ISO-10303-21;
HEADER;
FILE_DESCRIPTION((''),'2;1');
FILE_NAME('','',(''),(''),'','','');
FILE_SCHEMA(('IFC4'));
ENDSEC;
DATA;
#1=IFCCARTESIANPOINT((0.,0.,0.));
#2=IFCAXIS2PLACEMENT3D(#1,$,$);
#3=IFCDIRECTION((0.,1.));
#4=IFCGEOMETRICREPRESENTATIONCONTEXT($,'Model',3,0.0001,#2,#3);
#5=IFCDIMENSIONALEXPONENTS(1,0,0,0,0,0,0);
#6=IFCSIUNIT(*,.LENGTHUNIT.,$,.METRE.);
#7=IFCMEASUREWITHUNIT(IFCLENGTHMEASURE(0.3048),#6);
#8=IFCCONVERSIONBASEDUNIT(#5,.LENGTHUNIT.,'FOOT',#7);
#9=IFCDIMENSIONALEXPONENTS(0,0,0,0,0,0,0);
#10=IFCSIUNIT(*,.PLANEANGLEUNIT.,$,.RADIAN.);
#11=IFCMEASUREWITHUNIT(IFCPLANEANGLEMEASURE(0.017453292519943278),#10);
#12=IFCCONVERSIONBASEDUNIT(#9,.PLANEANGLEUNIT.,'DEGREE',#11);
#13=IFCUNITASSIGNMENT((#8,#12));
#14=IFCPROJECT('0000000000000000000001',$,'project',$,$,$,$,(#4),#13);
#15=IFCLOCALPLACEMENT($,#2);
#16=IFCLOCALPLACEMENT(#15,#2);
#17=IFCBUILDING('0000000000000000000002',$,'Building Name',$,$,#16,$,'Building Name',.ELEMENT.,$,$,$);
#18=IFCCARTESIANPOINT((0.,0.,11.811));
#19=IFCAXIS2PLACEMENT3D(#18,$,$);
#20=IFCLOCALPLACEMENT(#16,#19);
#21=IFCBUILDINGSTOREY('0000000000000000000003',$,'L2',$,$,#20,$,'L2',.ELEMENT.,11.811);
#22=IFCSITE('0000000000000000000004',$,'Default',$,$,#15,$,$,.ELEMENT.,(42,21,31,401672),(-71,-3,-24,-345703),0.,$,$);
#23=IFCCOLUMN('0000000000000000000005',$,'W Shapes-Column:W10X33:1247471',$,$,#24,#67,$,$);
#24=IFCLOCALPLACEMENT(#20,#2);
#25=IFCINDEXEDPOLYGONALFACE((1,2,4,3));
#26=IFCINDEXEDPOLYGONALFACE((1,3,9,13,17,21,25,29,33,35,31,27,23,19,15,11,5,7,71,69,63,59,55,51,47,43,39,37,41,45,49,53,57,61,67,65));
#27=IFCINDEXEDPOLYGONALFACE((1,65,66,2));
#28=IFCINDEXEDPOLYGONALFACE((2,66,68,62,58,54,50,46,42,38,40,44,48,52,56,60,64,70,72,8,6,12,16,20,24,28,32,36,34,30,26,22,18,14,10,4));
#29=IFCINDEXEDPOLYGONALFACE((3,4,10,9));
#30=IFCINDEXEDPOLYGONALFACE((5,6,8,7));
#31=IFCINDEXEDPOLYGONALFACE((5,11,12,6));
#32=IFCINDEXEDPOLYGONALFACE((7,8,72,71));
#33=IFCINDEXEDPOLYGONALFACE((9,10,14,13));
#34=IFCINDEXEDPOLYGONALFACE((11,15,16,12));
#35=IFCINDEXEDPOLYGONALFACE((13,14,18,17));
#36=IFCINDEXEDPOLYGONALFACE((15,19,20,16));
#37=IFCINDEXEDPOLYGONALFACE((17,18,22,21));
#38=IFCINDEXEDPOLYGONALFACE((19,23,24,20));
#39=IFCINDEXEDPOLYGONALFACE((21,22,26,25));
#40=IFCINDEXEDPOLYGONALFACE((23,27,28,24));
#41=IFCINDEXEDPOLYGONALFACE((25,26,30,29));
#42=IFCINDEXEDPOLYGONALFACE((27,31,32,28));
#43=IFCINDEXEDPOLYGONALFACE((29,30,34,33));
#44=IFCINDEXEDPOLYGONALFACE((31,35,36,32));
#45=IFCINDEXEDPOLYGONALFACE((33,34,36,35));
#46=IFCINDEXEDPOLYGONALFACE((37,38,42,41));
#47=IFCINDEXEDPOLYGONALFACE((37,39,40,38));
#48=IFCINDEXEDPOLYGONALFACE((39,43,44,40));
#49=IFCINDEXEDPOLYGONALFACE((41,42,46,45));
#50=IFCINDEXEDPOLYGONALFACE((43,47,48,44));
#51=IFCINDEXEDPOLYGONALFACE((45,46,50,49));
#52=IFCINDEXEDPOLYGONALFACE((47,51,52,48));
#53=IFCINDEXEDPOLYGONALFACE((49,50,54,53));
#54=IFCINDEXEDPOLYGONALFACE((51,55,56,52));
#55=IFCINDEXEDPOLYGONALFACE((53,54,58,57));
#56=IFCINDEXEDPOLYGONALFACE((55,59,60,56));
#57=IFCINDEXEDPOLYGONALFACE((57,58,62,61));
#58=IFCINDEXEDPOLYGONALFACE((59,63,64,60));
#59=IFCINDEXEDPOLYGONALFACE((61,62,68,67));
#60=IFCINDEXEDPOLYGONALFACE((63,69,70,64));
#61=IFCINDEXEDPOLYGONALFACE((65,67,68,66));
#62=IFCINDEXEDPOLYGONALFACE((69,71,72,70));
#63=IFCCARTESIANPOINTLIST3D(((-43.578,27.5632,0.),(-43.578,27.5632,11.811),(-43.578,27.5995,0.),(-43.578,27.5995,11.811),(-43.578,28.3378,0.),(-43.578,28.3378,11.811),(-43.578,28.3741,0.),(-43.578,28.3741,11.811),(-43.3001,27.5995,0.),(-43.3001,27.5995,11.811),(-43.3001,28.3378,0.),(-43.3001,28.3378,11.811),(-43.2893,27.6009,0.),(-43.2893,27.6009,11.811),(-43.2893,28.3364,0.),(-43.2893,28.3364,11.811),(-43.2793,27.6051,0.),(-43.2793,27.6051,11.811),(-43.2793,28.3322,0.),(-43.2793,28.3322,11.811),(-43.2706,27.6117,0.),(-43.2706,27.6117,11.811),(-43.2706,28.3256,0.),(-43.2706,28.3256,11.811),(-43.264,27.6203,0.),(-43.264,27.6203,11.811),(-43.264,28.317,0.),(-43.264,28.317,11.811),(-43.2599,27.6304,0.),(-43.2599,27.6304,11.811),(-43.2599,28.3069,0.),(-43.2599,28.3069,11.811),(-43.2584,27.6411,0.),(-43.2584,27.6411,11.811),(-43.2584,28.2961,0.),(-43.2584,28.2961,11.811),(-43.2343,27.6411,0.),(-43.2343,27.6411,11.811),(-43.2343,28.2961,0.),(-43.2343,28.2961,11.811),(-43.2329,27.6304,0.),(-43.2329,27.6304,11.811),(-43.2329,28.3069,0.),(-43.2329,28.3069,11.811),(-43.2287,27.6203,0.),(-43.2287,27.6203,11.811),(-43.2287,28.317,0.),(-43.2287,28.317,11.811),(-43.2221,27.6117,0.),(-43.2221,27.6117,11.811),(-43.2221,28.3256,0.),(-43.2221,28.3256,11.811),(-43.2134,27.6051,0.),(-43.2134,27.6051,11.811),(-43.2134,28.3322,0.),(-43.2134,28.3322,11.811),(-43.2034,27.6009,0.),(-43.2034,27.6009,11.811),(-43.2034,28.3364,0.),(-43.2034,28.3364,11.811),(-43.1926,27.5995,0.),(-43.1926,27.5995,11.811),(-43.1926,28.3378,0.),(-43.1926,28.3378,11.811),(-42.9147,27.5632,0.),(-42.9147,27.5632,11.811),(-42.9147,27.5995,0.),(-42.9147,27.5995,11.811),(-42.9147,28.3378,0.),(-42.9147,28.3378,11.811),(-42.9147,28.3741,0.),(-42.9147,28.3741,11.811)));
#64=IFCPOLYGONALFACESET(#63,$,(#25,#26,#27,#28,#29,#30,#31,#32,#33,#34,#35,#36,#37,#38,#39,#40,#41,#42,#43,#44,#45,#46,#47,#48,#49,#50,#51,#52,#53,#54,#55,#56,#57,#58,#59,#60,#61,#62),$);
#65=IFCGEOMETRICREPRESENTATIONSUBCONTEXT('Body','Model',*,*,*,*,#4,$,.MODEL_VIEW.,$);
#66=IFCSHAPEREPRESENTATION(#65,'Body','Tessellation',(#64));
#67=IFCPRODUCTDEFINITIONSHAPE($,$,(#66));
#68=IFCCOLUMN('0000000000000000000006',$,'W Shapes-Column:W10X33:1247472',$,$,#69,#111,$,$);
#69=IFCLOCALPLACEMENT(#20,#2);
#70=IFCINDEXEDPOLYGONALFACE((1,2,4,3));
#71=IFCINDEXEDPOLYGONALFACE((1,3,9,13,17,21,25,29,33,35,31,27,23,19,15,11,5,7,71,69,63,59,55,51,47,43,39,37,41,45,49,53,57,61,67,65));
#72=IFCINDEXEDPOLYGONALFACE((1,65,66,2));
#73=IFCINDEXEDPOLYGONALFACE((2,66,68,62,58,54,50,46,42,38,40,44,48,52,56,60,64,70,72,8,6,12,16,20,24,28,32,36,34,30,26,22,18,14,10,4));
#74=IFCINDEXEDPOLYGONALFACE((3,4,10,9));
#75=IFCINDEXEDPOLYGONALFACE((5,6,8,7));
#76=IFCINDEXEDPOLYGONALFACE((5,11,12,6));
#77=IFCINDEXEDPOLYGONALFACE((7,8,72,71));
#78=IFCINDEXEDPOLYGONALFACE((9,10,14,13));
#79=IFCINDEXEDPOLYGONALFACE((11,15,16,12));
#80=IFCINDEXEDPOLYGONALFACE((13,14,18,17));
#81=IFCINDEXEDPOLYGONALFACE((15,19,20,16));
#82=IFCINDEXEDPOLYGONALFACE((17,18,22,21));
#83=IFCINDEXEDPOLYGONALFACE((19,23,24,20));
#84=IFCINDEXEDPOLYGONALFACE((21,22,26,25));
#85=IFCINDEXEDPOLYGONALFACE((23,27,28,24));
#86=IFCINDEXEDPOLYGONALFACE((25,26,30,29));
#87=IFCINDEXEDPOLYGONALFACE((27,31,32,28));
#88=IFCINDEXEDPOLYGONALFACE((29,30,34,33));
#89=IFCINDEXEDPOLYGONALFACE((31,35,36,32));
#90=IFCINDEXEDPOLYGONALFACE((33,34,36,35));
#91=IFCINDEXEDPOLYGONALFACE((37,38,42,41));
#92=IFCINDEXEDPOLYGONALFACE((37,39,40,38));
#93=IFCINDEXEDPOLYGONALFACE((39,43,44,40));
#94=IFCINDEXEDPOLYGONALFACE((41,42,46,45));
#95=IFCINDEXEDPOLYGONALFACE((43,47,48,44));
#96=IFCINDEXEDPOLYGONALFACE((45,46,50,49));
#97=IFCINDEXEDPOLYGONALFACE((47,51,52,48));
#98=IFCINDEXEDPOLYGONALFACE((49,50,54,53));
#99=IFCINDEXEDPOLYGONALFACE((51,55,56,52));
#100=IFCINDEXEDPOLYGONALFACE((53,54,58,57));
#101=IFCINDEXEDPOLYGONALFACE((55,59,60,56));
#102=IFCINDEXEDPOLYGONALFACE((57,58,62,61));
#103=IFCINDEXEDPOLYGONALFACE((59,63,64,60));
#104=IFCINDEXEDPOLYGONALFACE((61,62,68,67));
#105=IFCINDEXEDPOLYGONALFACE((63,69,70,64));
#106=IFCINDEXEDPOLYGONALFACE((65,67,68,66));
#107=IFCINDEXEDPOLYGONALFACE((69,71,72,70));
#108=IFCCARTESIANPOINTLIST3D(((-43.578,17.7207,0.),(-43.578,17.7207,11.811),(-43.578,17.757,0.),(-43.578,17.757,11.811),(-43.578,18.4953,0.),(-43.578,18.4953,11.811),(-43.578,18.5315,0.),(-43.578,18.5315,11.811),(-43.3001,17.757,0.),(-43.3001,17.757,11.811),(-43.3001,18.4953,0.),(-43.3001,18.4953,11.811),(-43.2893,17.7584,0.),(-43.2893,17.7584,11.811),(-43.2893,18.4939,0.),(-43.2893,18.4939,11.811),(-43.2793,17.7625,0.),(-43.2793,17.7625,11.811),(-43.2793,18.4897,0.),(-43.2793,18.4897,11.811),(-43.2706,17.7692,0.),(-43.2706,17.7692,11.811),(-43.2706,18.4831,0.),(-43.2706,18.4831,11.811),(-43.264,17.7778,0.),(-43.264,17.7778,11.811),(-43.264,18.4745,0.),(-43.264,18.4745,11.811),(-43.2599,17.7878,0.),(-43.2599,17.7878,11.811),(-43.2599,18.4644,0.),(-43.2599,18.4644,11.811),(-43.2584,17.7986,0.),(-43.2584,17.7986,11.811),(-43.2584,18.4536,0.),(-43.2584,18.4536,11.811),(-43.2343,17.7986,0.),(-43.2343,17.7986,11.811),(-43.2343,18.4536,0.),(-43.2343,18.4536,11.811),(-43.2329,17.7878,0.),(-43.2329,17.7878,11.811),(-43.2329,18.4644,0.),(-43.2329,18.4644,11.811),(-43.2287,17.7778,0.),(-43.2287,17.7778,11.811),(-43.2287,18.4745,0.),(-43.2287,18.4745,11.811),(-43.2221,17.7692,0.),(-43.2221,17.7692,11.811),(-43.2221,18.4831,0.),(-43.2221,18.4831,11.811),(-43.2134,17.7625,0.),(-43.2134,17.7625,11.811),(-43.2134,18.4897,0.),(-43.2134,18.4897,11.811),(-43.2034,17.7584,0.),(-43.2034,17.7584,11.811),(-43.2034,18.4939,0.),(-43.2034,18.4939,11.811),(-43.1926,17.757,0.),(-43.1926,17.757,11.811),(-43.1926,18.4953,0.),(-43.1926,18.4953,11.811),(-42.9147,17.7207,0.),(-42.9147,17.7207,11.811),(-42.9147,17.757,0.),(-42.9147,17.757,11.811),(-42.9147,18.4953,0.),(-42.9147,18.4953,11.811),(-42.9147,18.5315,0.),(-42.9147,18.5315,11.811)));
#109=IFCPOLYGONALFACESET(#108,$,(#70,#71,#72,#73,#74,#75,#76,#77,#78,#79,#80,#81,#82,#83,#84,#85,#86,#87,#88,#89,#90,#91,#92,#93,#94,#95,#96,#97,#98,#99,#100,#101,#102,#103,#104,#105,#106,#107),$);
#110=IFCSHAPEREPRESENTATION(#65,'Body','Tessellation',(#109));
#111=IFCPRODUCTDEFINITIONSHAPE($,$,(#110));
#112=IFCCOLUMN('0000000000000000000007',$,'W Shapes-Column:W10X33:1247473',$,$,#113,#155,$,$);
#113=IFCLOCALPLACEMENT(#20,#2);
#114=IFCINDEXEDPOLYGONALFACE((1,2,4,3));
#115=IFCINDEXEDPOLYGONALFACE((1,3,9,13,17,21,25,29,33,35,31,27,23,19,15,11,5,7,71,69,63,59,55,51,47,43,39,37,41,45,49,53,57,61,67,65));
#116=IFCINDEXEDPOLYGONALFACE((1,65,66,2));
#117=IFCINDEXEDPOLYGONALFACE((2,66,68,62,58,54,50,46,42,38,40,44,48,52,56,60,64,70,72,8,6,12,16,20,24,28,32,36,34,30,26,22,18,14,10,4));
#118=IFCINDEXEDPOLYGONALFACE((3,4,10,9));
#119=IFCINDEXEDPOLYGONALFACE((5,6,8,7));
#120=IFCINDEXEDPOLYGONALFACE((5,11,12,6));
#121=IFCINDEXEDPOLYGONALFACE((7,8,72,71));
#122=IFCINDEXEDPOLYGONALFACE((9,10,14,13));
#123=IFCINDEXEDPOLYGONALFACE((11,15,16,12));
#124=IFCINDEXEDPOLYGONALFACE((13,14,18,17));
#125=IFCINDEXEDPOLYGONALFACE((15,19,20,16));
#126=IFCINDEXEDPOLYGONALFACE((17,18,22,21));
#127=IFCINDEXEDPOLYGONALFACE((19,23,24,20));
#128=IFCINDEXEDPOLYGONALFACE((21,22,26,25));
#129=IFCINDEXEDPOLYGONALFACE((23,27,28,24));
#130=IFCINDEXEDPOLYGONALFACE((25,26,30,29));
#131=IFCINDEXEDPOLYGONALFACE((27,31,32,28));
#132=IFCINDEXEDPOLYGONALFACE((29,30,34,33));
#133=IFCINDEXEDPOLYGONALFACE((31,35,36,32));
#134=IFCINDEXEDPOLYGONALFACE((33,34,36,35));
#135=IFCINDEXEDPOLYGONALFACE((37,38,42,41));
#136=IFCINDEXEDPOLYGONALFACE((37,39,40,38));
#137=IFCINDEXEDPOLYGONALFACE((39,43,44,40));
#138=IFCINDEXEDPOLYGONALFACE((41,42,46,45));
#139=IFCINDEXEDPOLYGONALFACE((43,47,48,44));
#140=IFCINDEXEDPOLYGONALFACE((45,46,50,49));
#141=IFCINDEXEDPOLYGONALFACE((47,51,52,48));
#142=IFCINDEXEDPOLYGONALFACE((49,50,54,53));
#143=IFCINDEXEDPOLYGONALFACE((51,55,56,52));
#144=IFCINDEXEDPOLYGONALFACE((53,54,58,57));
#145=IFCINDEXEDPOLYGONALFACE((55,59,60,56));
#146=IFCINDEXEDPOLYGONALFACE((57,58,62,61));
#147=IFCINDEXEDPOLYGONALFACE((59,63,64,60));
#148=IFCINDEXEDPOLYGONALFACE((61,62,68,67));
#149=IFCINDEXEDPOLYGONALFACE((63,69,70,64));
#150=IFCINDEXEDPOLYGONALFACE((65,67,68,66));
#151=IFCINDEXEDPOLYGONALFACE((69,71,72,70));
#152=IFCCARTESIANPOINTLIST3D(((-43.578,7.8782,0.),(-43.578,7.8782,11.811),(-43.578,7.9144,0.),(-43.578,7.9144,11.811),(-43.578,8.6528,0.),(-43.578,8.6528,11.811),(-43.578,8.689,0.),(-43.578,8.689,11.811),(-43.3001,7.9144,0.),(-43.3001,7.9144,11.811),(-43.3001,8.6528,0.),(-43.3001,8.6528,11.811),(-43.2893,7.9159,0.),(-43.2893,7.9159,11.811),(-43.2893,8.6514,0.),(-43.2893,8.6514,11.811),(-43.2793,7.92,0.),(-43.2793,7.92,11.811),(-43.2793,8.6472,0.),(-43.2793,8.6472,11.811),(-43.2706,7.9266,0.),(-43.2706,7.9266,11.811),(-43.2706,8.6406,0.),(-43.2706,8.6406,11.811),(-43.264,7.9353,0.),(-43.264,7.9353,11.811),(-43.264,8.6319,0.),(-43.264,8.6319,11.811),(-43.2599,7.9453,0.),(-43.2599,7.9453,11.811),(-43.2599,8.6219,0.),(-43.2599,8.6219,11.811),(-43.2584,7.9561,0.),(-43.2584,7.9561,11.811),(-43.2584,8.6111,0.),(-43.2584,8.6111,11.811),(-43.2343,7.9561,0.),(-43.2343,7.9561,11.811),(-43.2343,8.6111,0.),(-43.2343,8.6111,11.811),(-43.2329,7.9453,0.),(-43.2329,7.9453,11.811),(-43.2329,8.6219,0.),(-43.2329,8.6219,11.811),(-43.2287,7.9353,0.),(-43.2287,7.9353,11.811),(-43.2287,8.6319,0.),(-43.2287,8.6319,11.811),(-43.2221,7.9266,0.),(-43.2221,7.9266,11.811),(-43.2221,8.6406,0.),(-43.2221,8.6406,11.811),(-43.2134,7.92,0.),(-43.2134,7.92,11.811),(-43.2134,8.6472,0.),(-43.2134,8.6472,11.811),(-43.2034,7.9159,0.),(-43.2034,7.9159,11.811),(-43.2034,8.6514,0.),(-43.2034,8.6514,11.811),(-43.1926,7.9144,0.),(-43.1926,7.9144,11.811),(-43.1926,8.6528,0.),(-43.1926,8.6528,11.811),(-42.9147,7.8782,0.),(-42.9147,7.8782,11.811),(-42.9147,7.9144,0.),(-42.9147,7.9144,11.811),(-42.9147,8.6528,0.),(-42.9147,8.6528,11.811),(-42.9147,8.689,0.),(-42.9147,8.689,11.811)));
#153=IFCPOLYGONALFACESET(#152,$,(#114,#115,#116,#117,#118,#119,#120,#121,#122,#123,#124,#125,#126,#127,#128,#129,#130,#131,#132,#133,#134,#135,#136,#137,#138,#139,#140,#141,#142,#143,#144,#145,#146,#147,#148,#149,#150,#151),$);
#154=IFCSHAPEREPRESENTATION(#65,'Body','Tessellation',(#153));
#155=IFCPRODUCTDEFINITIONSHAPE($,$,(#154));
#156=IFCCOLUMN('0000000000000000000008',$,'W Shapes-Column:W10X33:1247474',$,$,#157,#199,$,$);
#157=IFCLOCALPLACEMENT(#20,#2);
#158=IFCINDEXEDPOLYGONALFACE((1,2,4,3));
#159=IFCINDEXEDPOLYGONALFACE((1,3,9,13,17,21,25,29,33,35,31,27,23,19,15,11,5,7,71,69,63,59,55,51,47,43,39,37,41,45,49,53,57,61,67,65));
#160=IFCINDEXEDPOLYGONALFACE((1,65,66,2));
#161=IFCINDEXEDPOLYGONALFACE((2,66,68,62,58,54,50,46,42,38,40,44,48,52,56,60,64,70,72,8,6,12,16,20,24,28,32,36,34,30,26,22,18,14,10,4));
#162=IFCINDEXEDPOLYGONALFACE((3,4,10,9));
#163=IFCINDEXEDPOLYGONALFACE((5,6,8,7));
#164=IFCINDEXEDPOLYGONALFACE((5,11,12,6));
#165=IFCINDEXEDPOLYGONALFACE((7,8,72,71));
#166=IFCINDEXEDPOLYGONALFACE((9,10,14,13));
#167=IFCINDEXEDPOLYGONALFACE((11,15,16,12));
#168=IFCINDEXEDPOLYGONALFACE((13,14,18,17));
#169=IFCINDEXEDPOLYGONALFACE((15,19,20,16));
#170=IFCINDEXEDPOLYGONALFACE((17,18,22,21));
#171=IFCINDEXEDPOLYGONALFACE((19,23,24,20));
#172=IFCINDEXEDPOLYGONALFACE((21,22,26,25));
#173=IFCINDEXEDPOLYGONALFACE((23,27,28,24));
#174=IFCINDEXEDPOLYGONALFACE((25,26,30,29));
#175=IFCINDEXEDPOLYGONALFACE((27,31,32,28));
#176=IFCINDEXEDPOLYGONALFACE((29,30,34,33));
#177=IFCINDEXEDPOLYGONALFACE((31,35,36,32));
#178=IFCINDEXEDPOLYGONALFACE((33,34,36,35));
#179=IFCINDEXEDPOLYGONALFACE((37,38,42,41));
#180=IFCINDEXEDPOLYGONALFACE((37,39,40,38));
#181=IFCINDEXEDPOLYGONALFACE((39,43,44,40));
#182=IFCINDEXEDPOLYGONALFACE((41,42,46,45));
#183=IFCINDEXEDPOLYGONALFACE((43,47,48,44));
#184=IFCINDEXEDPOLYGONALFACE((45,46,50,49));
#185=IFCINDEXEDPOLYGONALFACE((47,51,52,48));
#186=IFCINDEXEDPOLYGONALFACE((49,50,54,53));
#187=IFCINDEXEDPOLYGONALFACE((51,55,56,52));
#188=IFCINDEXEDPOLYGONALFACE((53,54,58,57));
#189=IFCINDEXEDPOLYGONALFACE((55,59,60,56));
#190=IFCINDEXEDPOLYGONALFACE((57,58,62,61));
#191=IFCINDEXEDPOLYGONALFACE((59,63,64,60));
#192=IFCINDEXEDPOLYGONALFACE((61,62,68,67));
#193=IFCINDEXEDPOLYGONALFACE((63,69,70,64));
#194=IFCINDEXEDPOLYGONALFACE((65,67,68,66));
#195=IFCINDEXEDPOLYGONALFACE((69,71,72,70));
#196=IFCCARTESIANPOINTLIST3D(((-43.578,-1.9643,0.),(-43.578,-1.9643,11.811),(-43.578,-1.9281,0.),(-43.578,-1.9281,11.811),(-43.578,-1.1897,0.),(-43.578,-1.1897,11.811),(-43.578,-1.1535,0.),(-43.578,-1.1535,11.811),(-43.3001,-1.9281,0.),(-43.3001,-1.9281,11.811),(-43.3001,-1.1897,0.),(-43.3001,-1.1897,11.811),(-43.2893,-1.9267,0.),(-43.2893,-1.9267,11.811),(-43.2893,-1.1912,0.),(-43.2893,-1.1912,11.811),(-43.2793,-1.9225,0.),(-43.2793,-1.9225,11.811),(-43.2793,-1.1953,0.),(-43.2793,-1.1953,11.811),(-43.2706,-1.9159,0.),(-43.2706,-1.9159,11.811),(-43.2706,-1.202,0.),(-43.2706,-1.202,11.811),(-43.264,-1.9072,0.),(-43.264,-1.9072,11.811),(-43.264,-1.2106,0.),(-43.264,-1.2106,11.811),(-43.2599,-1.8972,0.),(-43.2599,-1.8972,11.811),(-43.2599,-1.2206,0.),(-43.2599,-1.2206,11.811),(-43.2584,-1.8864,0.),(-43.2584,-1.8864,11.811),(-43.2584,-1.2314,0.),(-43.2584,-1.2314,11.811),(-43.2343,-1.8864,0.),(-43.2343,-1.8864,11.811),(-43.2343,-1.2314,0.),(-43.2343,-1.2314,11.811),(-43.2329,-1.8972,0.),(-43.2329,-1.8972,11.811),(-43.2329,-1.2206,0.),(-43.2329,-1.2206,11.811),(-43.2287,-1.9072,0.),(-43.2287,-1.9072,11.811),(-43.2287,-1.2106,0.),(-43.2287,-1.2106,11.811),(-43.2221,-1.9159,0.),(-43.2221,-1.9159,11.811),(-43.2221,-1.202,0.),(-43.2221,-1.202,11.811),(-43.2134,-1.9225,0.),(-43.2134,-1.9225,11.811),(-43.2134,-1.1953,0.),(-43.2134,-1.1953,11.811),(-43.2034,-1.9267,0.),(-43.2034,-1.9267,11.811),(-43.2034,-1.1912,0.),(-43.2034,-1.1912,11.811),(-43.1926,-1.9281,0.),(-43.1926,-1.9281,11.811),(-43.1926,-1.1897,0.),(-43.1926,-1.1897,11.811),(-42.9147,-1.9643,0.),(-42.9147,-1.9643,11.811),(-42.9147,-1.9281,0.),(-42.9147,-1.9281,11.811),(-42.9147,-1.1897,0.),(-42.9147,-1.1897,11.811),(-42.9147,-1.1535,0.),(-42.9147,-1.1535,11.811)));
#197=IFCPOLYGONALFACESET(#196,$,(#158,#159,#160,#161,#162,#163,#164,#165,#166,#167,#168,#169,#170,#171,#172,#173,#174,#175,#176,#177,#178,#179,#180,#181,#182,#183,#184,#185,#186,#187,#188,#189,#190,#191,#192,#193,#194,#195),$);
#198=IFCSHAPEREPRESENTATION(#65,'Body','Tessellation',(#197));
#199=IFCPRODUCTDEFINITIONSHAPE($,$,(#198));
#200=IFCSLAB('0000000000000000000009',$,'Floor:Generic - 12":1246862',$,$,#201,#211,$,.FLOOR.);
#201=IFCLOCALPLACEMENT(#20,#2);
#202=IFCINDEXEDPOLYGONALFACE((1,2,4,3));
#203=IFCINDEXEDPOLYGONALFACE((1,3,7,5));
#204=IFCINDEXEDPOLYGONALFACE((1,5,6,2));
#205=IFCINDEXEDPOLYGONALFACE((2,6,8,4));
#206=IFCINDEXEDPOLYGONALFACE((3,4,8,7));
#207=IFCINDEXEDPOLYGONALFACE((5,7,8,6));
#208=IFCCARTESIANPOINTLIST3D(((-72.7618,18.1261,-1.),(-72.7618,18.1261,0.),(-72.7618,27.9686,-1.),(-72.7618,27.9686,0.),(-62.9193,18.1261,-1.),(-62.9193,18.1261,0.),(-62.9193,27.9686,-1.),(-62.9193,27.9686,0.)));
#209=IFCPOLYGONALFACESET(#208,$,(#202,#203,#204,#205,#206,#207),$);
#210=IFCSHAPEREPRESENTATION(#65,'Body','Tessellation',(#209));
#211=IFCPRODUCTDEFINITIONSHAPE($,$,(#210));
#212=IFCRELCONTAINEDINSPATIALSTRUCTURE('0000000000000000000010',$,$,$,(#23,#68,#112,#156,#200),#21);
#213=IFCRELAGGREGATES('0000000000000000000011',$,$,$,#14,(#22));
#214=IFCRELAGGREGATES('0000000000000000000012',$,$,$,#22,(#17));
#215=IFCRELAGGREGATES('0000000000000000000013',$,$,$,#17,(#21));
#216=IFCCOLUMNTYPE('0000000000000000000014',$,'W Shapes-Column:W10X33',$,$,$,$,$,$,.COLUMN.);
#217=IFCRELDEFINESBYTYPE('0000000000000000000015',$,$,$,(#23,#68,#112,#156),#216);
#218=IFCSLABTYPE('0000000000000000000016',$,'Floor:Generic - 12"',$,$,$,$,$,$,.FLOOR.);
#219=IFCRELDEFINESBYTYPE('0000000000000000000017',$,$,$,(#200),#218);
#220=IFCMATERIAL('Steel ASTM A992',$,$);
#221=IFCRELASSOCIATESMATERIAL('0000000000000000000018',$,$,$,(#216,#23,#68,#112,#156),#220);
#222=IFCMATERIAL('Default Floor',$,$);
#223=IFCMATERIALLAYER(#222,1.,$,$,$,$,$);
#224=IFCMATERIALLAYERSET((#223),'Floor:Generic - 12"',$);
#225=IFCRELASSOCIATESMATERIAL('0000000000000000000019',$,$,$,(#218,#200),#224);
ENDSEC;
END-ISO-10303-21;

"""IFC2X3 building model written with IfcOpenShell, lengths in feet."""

from ifc_helpers import new_model, entity, si_unit, converted_unit, direction, frame, frame_2d, origin, origin_2d_with_axis, place, context, subcontext, project, spatial, rectangle, i_section, extrude, source, transform, mapped, material, layer, layer_set, layer_usage, type_object, type_shapes, element, save


model = new_model("IFC2X3")

# Units and contexts
model_context = context("Model", 3, precision=0.0001, world=origin(), true_north=direction((0.0, 1.0)))
body_context = subcontext(model_context, "Body", "Model", "MODEL_VIEW")
ifc_project = project(units=[converted_unit("LENGTHUNIT", "FOOT", entity("IfcLengthMeasure", 0.3048), si_unit("LENGTHUNIT", "METRE"), dimensions=[1, 0, 0, 0, 0, 0, 0]), converted_unit("PLANEANGLEUNIT", "DEGREE", entity("IfcPlaneAngleMeasure", 0.017453292519943278), si_unit("PLANEANGLEUNIT", "RADIAN"), dimensions=[0, 0, 0, 0, 0, 0, 0])], contexts=[model_context])

# Site, building, storey
site_placement = place(None, origin())
site = spatial("IfcSite", under=ifc_project, at=site_placement, Name="Default", CompositionType="ELEMENT", RefLatitude=(42, 21, 31, 401672), RefLongitude=(-71, -3, -24, -345703), RefElevation=0.0)
building_placement = place(site_placement, origin())
building = spatial("IfcBuilding", under=site, at=building_placement, Name="Building Name", LongName="Building Name", CompositionType="ELEMENT")
storey_placement = place(building_placement, frame((0.0, 0.0, 11.811)))
storey = spatial("IfcBuildingStorey", under=building, at=storey_placement, Name="L2", LongName="L2", CompositionType="ELEMENT", Elevation=11.811)

# Columns
ifc_material_1 = material(Name="Steel ASTM A992")
column_type = type_object("IfcColumnType", Name="W Shapes-Column:W10X33", PredefinedType="COLUMN", material=ifc_material_1)
shared_shape = source(origin(), body_context, "Body", "SweptSolid", [
    extrude(i_section(OverallWidth=0.6633, OverallDepth=0.8108, WebThickness=0.0242, FlangeThickness=0.0362, FilletRadius=0.0417, at=frame_2d((0.0, 0.0), x_axis=(1.0, 0.0))), frame((0.0, 0.0, 11.811), z_axis=(0.0, 0.0, 1.0), x_axis=(-1.0, 0.0, 0.0)), (0.0, 0.0, 1.0), 11.811),
])
type_shapes(column_type, [shared_shape])
for number, where, name in (
    (1, (-43.2464, 27.9686, -11.811), "W Shapes-Column:W10X33:1247471"),
    (2, (-43.2464, 18.1261, -11.811), "W Shapes-Column:W10X33:1247472"),
    (3, (-43.2464, 8.2836, -11.811), "W Shapes-Column:W10X33:1247473"),
    (4, (-43.2464, -1.5589, -11.811), "W Shapes-Column:W10X33:1247474"),
):
    element("IfcColumn", number, at=place(storey_placement, frame(where)), inside=storey, type_object=column_type, material=ifc_material_1, Name=name, context=body_context, shape_type="MappedRepresentation", body=[
        mapped(shared_shape, transform((0.0, 0.0, 0.0), scale=1.0)),
    ])

# Slab
ifc_material_2 = material(Name="Default Floor")
ifc_layer = layer(ifc_material_2, 1.0)
ifc_layer_set = layer_set([ifc_layer], Name="Floor:Generic - 12\"")
ifc_layer_usage_1 = layer_usage(ifc_layer_set, "AXIS3", "POSITIVE", 0.0)
slab_type = type_object("IfcSlabType", Name="Floor:Generic - 12\"", PredefinedType="FLOOR", material=ifc_layer_set)
slab_1_placement = place(storey_placement, origin())
element("IfcSlab", 5, at=slab_1_placement, inside=storey, type_object=slab_type, material=ifc_layer_usage_1, Name="Floor:Generic - 12\":1246862", PredefinedType="FLOOR", context=body_context, shape_type="SweptSolid", body=[
    extrude(rectangle(XDim=9.8425, YDim=9.8425, at=origin_2d_with_axis()), frame((-67.8406, 23.0474, 0.0), z_axis=(0.0, 0.0, -1.0), x_axis=(0.0, 1.0, 0.0)), (0.0, 0.0, 1.0), 1.0),
])

save(model, "model.ifc")
